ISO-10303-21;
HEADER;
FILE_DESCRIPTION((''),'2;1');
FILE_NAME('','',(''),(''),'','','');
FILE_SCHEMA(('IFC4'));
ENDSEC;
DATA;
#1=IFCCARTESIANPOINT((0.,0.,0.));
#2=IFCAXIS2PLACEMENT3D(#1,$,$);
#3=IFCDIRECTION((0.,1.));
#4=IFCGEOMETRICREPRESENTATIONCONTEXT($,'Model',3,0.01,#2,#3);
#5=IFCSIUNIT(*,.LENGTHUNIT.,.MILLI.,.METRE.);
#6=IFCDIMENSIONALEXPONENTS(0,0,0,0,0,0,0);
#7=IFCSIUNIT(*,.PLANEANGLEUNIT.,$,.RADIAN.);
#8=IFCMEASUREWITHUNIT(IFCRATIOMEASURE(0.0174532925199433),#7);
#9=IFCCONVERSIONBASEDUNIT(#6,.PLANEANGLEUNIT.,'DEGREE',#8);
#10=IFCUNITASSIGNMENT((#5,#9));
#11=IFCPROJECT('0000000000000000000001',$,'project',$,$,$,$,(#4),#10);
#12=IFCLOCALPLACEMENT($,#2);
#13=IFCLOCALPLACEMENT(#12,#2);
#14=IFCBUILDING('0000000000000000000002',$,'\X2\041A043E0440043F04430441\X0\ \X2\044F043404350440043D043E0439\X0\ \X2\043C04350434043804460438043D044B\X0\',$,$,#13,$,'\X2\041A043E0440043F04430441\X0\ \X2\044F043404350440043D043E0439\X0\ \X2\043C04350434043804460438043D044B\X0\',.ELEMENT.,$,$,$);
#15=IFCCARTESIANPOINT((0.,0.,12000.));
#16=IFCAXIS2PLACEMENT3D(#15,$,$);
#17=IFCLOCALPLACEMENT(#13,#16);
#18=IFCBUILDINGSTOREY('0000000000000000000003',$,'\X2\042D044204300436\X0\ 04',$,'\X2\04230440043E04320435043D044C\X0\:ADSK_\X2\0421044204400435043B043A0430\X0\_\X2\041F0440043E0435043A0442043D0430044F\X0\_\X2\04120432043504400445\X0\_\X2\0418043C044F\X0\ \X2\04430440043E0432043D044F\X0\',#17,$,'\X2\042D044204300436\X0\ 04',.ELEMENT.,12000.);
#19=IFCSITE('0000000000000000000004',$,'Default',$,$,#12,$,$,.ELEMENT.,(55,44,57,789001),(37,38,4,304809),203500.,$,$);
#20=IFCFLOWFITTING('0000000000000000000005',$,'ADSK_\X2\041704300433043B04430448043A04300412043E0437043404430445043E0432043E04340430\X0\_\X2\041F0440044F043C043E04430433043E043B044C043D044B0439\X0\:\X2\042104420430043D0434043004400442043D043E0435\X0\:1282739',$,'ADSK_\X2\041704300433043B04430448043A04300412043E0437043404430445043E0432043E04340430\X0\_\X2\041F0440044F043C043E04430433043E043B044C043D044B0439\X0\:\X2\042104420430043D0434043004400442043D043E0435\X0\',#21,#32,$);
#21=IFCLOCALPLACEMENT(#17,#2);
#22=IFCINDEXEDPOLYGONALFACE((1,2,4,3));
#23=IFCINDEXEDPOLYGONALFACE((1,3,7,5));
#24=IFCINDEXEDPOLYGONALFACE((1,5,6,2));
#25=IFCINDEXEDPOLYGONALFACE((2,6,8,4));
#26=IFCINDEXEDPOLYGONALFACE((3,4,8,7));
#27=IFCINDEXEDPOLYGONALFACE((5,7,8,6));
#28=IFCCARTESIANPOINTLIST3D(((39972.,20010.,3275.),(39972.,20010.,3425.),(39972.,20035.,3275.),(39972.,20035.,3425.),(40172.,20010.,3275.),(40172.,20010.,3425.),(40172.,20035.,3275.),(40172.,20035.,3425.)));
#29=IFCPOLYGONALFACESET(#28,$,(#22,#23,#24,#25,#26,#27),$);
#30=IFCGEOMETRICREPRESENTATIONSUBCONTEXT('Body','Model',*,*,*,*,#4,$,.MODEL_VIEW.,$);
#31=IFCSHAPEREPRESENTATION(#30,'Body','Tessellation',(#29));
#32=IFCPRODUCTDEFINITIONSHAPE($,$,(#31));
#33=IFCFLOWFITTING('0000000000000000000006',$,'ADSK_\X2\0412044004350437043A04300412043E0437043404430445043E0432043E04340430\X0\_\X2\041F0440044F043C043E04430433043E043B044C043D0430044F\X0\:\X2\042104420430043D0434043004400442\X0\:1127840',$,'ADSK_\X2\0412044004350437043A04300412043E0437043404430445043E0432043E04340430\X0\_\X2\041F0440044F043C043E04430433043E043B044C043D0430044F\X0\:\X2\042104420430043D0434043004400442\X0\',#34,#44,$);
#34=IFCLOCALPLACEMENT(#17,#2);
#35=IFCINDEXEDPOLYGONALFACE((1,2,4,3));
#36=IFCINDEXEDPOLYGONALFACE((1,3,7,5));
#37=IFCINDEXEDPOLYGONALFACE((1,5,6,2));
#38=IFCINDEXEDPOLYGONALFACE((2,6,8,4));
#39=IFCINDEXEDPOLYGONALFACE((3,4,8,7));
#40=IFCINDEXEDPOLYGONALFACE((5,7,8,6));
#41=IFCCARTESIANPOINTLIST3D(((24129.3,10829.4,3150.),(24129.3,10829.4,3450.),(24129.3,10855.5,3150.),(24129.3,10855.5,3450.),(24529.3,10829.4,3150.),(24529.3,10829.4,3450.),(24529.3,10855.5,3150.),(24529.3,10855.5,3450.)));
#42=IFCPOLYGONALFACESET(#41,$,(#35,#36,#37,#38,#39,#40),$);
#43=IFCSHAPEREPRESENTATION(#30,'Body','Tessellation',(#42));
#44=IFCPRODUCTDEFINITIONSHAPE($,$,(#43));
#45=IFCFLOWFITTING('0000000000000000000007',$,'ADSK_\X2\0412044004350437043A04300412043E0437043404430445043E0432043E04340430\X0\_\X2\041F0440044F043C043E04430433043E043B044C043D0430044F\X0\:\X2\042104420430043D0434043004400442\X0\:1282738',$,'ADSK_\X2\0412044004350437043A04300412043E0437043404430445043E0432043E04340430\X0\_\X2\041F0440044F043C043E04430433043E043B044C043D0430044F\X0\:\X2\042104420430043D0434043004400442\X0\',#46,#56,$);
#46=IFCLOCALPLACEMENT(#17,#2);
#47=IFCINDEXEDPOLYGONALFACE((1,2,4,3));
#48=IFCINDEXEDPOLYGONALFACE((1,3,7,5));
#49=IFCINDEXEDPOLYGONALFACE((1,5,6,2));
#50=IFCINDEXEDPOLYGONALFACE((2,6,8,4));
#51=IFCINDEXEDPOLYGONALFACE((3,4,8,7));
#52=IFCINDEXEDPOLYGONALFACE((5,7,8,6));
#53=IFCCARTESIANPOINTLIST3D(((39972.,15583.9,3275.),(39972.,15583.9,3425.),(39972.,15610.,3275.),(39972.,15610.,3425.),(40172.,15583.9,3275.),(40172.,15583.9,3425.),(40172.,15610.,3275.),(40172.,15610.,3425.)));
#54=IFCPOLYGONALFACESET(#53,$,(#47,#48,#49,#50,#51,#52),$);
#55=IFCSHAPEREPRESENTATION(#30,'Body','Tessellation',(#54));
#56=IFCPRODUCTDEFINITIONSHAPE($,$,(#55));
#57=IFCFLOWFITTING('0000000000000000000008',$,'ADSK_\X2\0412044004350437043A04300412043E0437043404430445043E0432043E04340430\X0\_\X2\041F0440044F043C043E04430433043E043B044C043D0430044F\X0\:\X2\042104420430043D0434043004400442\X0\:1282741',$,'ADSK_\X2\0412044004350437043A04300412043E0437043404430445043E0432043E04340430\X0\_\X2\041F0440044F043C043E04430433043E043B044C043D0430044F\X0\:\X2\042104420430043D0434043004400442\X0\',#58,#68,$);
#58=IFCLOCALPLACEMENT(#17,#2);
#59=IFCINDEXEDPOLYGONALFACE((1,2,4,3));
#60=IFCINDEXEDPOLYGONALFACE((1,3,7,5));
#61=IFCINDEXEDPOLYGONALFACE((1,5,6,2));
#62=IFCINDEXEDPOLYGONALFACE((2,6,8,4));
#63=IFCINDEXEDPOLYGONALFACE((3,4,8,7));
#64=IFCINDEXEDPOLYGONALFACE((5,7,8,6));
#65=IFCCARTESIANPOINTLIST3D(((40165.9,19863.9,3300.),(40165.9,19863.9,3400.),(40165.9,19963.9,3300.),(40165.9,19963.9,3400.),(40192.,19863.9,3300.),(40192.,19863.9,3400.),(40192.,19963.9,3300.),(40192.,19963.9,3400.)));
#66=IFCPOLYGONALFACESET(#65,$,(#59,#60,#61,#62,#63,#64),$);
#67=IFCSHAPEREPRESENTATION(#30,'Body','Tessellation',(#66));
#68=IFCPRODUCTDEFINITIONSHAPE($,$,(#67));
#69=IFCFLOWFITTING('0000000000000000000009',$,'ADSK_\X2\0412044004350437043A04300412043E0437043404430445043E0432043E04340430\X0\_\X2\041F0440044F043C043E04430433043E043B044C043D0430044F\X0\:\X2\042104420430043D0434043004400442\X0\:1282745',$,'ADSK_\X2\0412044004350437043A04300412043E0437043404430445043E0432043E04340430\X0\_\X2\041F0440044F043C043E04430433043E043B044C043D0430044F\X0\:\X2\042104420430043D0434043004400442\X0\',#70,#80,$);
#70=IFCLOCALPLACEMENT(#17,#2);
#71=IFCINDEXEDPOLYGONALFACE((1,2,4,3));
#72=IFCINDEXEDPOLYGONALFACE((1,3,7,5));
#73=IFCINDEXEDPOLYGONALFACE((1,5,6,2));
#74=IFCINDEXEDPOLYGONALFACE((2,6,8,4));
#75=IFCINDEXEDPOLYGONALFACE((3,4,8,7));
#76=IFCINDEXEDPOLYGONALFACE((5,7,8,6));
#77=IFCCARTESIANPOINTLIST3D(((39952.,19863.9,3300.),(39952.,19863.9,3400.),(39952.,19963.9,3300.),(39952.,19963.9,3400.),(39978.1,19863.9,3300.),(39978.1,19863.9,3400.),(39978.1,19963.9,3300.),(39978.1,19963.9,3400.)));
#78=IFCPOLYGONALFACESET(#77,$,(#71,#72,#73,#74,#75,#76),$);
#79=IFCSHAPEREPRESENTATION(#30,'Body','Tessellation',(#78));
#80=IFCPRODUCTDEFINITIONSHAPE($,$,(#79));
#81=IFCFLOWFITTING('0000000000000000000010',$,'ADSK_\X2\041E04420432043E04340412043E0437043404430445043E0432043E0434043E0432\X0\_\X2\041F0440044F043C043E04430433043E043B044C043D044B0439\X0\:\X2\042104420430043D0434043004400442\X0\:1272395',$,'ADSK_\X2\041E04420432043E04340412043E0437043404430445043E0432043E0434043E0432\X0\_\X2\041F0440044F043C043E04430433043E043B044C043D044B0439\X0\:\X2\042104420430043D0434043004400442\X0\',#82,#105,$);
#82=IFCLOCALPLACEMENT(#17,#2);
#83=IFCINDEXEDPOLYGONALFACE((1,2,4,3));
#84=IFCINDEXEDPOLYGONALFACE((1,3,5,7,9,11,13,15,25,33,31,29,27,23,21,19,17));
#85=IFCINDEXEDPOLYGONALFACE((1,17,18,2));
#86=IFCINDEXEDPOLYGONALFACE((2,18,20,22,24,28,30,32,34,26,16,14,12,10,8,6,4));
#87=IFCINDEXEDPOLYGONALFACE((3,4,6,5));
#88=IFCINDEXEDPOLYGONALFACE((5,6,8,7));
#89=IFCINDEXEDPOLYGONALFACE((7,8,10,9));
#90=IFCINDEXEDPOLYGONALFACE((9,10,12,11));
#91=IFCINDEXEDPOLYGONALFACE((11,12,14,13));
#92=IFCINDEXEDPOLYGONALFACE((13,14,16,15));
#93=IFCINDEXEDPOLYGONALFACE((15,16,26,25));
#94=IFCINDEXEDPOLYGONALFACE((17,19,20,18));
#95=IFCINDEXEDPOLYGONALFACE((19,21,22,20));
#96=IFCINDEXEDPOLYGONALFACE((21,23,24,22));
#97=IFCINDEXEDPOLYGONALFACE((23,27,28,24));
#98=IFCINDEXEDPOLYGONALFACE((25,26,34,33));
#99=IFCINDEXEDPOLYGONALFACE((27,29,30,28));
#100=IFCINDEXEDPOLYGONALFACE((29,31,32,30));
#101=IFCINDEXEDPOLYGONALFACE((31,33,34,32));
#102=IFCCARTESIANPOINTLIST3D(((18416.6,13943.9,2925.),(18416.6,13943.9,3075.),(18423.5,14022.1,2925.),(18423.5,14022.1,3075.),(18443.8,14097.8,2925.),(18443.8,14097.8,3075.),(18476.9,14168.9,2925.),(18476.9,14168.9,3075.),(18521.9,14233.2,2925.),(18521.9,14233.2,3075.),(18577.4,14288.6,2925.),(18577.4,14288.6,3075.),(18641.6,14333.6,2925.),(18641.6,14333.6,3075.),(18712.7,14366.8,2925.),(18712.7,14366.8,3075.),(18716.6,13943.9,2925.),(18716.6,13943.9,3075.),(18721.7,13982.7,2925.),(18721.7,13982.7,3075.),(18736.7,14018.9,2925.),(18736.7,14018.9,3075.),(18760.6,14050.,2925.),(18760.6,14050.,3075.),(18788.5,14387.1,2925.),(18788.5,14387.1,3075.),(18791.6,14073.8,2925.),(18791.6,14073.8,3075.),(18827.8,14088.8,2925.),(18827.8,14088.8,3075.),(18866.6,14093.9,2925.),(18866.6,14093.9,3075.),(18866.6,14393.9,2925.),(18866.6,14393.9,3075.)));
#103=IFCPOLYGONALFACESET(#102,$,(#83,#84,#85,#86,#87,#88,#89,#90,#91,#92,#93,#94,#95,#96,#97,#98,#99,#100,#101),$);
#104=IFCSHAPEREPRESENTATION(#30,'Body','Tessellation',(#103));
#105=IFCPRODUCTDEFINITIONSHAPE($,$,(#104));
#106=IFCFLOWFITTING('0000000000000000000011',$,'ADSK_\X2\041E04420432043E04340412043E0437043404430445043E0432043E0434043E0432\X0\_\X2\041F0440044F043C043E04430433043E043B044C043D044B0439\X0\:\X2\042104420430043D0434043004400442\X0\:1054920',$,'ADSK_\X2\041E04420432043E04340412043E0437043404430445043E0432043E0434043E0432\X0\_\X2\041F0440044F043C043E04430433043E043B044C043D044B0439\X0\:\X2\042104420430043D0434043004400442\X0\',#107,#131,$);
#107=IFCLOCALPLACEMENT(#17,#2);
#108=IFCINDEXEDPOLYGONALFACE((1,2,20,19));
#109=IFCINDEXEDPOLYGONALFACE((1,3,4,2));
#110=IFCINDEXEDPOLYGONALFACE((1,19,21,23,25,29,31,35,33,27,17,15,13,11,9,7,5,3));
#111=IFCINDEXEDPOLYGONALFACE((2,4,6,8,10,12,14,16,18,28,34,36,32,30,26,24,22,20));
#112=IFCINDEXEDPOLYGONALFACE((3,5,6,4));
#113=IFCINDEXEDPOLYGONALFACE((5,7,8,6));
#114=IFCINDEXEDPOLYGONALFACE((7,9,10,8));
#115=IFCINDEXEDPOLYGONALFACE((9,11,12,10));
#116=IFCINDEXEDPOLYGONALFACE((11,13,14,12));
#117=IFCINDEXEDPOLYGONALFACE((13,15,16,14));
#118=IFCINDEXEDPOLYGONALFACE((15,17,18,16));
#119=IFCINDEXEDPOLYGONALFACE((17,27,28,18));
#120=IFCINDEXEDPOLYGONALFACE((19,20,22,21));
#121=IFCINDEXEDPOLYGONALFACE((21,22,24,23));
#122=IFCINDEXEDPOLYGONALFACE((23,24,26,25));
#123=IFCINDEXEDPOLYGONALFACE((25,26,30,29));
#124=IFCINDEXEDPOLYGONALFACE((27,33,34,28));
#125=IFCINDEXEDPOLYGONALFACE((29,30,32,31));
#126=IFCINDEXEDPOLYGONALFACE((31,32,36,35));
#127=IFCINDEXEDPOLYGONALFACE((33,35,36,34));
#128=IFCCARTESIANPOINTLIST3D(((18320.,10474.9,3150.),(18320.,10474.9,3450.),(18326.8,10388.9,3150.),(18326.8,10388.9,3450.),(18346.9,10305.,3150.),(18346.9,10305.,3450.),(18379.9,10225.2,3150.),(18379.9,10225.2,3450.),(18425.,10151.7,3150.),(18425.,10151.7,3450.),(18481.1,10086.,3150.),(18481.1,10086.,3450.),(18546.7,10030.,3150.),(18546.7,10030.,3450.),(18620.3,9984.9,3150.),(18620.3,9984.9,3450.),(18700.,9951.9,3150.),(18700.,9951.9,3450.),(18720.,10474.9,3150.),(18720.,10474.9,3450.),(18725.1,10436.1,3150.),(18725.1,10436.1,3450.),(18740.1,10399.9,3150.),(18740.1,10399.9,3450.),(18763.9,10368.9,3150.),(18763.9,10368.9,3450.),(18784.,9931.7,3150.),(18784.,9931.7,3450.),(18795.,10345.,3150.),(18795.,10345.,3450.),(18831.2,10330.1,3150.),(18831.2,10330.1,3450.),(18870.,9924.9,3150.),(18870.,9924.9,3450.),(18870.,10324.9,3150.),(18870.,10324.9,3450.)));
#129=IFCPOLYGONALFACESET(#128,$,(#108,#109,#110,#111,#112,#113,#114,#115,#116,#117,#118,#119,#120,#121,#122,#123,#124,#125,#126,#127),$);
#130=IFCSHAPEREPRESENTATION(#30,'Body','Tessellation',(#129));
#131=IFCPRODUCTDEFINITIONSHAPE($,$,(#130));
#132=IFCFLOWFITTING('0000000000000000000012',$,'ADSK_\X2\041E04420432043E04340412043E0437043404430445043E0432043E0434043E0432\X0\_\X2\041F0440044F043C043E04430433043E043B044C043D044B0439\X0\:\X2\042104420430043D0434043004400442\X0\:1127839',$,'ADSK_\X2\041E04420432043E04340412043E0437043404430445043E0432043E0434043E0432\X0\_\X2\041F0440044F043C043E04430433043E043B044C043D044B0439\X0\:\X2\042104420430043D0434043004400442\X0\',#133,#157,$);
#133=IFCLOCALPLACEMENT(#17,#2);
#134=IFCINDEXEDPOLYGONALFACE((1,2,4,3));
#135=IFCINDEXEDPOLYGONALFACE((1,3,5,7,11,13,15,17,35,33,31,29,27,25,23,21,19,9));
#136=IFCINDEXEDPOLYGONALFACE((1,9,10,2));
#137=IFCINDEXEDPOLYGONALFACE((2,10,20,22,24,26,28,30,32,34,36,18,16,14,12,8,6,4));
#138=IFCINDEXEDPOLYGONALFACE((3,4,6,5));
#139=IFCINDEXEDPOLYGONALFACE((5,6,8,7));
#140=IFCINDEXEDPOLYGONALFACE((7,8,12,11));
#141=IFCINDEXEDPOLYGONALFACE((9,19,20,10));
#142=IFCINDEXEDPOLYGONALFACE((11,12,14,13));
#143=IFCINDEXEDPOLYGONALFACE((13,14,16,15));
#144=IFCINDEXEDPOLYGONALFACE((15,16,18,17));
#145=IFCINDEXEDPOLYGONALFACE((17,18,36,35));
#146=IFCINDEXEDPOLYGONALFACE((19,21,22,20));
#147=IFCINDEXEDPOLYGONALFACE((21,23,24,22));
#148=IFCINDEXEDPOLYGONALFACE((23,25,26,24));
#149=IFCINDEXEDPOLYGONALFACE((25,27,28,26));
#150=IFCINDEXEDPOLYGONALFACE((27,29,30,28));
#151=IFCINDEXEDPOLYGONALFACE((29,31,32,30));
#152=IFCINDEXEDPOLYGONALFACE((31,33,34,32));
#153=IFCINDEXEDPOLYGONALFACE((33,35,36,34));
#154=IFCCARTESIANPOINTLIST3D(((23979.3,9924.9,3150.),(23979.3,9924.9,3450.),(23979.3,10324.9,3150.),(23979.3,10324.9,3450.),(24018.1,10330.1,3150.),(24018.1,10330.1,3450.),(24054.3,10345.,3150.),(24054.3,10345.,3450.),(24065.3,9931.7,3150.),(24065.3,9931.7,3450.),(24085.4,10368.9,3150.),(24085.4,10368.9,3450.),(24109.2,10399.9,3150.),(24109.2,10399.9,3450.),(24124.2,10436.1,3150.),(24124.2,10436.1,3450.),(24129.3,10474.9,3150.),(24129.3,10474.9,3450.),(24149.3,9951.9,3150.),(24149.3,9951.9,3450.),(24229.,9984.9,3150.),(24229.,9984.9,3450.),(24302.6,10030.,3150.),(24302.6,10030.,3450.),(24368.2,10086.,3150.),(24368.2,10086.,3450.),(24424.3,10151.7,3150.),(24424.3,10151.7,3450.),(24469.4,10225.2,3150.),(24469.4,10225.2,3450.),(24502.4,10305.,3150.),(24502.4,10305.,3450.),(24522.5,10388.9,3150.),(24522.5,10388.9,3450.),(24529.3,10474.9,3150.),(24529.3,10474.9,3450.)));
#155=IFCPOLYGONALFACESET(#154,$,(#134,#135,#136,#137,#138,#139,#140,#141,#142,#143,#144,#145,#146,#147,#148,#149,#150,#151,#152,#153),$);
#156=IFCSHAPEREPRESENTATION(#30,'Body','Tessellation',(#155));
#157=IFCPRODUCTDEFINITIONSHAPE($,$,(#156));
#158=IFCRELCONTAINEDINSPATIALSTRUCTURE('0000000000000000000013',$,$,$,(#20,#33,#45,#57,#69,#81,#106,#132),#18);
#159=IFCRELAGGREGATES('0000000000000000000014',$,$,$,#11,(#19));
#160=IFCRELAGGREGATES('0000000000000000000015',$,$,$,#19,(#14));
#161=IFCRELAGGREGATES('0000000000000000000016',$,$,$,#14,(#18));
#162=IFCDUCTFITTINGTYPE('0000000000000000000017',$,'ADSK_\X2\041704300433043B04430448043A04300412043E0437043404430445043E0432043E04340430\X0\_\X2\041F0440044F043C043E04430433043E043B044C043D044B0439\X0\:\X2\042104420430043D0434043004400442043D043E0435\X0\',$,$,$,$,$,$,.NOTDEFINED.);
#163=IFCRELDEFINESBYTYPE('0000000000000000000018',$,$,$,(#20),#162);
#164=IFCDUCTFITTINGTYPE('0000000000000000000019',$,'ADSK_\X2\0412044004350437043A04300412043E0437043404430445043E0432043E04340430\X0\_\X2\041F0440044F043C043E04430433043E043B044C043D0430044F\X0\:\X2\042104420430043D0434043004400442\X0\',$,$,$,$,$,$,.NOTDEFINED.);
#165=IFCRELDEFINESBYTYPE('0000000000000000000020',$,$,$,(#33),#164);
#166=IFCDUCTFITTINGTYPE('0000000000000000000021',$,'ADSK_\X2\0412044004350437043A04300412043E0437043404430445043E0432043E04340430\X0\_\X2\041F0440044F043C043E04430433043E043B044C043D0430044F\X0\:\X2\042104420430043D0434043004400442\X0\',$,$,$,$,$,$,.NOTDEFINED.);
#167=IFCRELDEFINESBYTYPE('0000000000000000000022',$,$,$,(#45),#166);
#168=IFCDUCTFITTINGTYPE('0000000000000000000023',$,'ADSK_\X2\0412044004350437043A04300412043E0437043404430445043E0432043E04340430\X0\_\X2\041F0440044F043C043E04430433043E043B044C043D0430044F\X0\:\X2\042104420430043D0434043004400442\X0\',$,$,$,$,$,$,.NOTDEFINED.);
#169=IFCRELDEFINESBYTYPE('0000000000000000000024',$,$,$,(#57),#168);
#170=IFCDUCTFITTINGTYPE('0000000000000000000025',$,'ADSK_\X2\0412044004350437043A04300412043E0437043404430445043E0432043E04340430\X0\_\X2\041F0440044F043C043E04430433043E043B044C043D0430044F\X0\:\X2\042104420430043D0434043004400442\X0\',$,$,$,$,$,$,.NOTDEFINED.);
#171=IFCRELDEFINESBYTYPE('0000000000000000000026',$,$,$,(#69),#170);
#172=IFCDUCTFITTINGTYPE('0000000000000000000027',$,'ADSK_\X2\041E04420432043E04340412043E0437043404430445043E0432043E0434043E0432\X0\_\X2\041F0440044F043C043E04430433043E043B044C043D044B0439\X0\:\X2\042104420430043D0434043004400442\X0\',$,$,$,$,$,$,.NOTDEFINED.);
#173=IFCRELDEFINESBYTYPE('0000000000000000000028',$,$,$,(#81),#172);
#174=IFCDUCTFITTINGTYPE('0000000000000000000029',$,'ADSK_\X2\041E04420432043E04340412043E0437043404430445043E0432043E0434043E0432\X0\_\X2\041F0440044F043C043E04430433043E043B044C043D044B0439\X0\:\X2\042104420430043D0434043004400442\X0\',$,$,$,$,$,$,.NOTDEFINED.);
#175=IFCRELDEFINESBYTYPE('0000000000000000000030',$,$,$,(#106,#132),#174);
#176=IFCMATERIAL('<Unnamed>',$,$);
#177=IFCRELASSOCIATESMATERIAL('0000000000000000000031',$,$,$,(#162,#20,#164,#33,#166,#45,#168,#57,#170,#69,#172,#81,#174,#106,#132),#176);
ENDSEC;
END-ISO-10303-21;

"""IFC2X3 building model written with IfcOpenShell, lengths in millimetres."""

from ifc_helpers import new_model, entity, si_unit, converted_unit, direction, frame, frame_2d, origin, origin_2d_with_axis, place, context, subcontext, project, spatial, polyline, circle_curve, parameter, trimmed, segment, composite_curve, rectangle, outline, extrude, source, transform, mapped, material, type_object, type_shapes, element, save


model = new_model("IFC2X3")

# Units and contexts
model_context = context("Model", 3, precision=0.01, world=origin(), true_north=direction((0.0, 1.0)))
body_context = subcontext(model_context, "Body", "Model", "MODEL_VIEW")
ifc_project = project(units=[si_unit("LENGTHUNIT", "METRE", prefix="MILLI"), converted_unit("PLANEANGLEUNIT", "DEGREE", entity("IfcRatioMeasure", 0.0174532925199433), si_unit("PLANEANGLEUNIT", "RADIAN"), dimensions=[0, 0, 0, 0, 0, 0, 0])], contexts=[model_context])

# Site, building, storey
site_placement = place(None, origin())
site = spatial("IfcSite", under=ifc_project, at=site_placement, Name="Default", CompositionType="ELEMENT", RefLatitude=(55, 44, 57, 789001), RefLongitude=(37, 38, 4, 304809), RefElevation=203500.0)
building_placement = place(site_placement, origin())
building = spatial("IfcBuilding", under=site, at=building_placement, Name="Корпус ядерной медицины", LongName="Корпус ядерной медицины", CompositionType="ELEMENT")
storey_placement = place(building_placement, frame((0.0, 0.0, 12000.0)))
storey = spatial("IfcBuildingStorey", under=building, at=storey_placement, Name="Этаж 04", ObjectType="Уровень:ADSK_Стрелка_Проектная_Вверх_Имя уровня", LongName="Этаж 04", CompositionType="ELEMENT", Elevation=12000.0)

# Flow fittings
ifc_material = material(Name="<Unnamed>")
duct_fitting_type_1 = type_object("IfcDuctFittingType", Name="ADSK_ЗаглушкаВоздуховода_Прямоугольный:Стандартное", PredefinedType="NOTDEFINED", material=ifc_material)
shared_shape_1 = source(origin(), body_context, "Body", "SweptSolid", [
    extrude(rectangle(XDim=25.0, YDim=200.0, at=origin_2d_with_axis()), frame((12.5, 0.0, -75.0)), (0.0, 0.0, 1.0), 150.0),
])
type_shapes(duct_fitting_type_1, [shared_shape_1])
flow_fitting_1_placement = place(storey_placement, frame((40072.0, 20010.0, 3350.0), z_axis=(0.0, 0.0, 1.0), x_axis=(0.0, 1.0, 0.0)))
element("IfcFlowFitting", 1, at=flow_fitting_1_placement, inside=storey, type_object=duct_fitting_type_1, material=ifc_material, Name="ADSK_ЗаглушкаВоздуховода_Прямоугольный:Стандартное:1282739", ObjectType="ADSK_ЗаглушкаВоздуховода_Прямоугольный:Стандартное", context=body_context, shape_type="MappedRepresentation", body=[
    mapped(shared_shape_1, transform((0.0, 0.0, 0.0), scale=1.0)),
])
duct_fitting_type_2 = type_object("IfcDuctFittingType", Name="ADSK_ВрезкаВоздуховода_Прямоугольная:Стандарт", PredefinedType="NOTDEFINED", material=ifc_material)
shared_shape_2 = source(origin(), body_context, "Body", "SweptSolid", [
    extrude(rectangle(XDim=26.1, YDim=300.0, at=origin_2d_with_axis()), frame((7.0, 0.0, -200.0)), (0.0, 0.0, 1.0), 400.0),
])
type_shapes(duct_fitting_type_2, [shared_shape_2])
flow_fitting_2_placement = place(storey_placement, frame((24329.3, 10849.4, 3300.0), z_axis=(-1.0, 0.0, 0.0), x_axis=(0.0, -1.0, 0.0)))
element("IfcFlowFitting", 2, at=flow_fitting_2_placement, inside=storey, type_object=duct_fitting_type_2, material=ifc_material, Name="ADSK_ВрезкаВоздуховода_Прямоугольная:Стандарт:1127840", ObjectType="ADSK_ВрезкаВоздуховода_Прямоугольная:Стандарт", context=body_context, shape_type="MappedRepresentation", body=[
    mapped(shared_shape_2, transform((0.0, 0.0, 0.0), scale=1.0)),
])
duct_fitting_type_3 = type_object("IfcDuctFittingType", Name="ADSK_ВрезкаВоздуховода_Прямоугольная:Стандарт", PredefinedType="NOTDEFINED", material=ifc_material)
shared_shape_3 = source(origin(), body_context, "Body", "SweptSolid", [
    extrude(rectangle(XDim=200.0, YDim=26.1, at=origin_2d_with_axis()), frame((7.0, 0.0, -75.0), z_axis=(0.0, 0.0, 1.0), x_axis=(0.0, -1.0, 0.0)), (0.0, 0.0, 1.0), 150.0),
])
type_shapes(duct_fitting_type_3, [shared_shape_3])
flow_fitting_3_placement = place(storey_placement, frame((40072.0, 15590.0, 3350.0), z_axis=(0.0, 0.0, -1.0), x_axis=(0.0, 1.0, 0.0)))
element("IfcFlowFitting", 3, at=flow_fitting_3_placement, inside=storey, type_object=duct_fitting_type_3, material=ifc_material, Name="ADSK_ВрезкаВоздуховода_Прямоугольная:Стандарт:1282738", ObjectType="ADSK_ВрезкаВоздуховода_Прямоугольная:Стандарт", context=body_context, shape_type="MappedRepresentation", body=[
    mapped(shared_shape_3, transform((0.0, 0.0, 0.0), scale=1.0)),
])
duct_fitting_type_4 = type_object("IfcDuctFittingType", Name="ADSK_ВрезкаВоздуховода_Прямоугольная:Стандарт", PredefinedType="NOTDEFINED", material=ifc_material)
shared_shape_4 = source(origin(), body_context, "Body", "SweptSolid", [
    extrude(rectangle(XDim=26.1, YDim=100.0, at=origin_2d_with_axis()), frame((7.0, 0.0, -50.0)), (0.0, 0.0, 1.0), 100.0),
])
type_shapes(duct_fitting_type_4, [shared_shape_4])
flow_fitting_4_placement = place(storey_placement, frame((40172.0, 19913.9, 3350.0), z_axis=(0.0, 0.0, -1.0), x_axis=(1.0, 0.0, 0.0)))
element("IfcFlowFitting", 4, at=flow_fitting_4_placement, inside=storey, type_object=duct_fitting_type_4, material=ifc_material, Name="ADSK_ВрезкаВоздуховода_Прямоугольная:Стандарт:1282741", ObjectType="ADSK_ВрезкаВоздуховода_Прямоугольная:Стандарт", context=body_context, shape_type="MappedRepresentation", body=[
    mapped(shared_shape_4, transform((0.0, 0.0, 0.0), scale=1.0)),
])
duct_fitting_type_5 = type_object("IfcDuctFittingType", Name="ADSK_ВрезкаВоздуховода_Прямоугольная:Стандарт", PredefinedType="NOTDEFINED", material=ifc_material)
shared_shape_5 = source(origin(), body_context, "Body", "SweptSolid", [
    extrude(rectangle(XDim=100.0, YDim=26.1, at=origin_2d_with_axis()), frame((7.0, 0.0, -50.0), z_axis=(0.0, 0.0, 1.0), x_axis=(0.0, -1.0, 0.0)), (0.0, 0.0, 1.0), 100.0),
])
type_shapes(duct_fitting_type_5, [shared_shape_5])
flow_fitting_5_placement = place(storey_placement, frame((39972.0, 19913.9, 3350.0), z_axis=(0.0, 0.0, -1.0), x_axis=(-1.0, 0.0, 0.0)))
element("IfcFlowFitting", 5, at=flow_fitting_5_placement, inside=storey, type_object=duct_fitting_type_5, material=ifc_material, Name="ADSK_ВрезкаВоздуховода_Прямоугольная:Стандарт:1282745", ObjectType="ADSK_ВрезкаВоздуховода_Прямоугольная:Стандарт", context=body_context, shape_type="MappedRepresentation", body=[
    mapped(shared_shape_5, transform((0.0, 0.0, 0.0), scale=1.0)),
])
duct_fitting_type_6 = type_object("IfcDuctFittingType", Name="ADSK_ОтводВоздуховодов_Прямоугольный:Стандарт", PredefinedType="NOTDEFINED", material=ifc_material)
shared_shape_6 = source(origin(), body_context, "Body", "SweptSolid", [
    extrude(outline(composite_curve([segment(polyline([(-300.0, -150.0), (0.0, -150.0)]), True, "CONTINUOUS"), segment(trimmed(circle_curve(frame_2d((150.0, -150.0), x_axis=(0.0, 1.0)), 150.0), [parameter(0.0)], [parameter(90.0)], True, "PARAMETER"), False, "CONTINUOUS"), segment(polyline([(150.0, 0.0), (150.0, 300.0)]), True, "CONTINUOUS"), segment(trimmed(circle_curve(frame_2d((150.0, -150.0), x_axis=(0.0, 1.0)), 450.0), [parameter(0.0)], [parameter(90.0)], True, "PARAMETER"), True, "CONTINUOUS")], self_intersect=False)), frame((-150.0, 150.0, -75.0), z_axis=(0.0, 0.0, 1.0), x_axis=(-1.0, 0.0, 0.0)), (0.0, 0.0, 1.0), 150.0),
])
type_shapes(duct_fitting_type_6, [shared_shape_6])
flow_fitting_6_placement = place(storey_placement, frame((18566.6, 14243.9, 3000.0), z_axis=(0.0, 0.0, 1.0), x_axis=(-1.0, 0.0, 0.0)))
element("IfcFlowFitting", 6, at=flow_fitting_6_placement, inside=storey, type_object=duct_fitting_type_6, material=ifc_material, Name="ADSK_ОтводВоздуховодов_Прямоугольный:Стандарт:1272395", ObjectType="ADSK_ОтводВоздуховодов_Прямоугольный:Стандарт", context=body_context, shape_type="MappedRepresentation", body=[
    mapped(shared_shape_6, transform((0.0, 0.0, 0.0), scale=1.0)),
])
duct_fitting_type_7 = type_object("IfcDuctFittingType", Name="ADSK_ОтводВоздуховодов_Прямоугольный:Стандарт", PredefinedType="NOTDEFINED", material=ifc_material)
shared_shape_7 = source(origin(), body_context, "Body", "SweptSolid", [
    extrude(outline(composite_curve([segment(polyline([(-375.0, -175.0), (25.0, -175.0)]), True, "CONTINUOUS"), segment(trimmed(circle_curve(frame_2d((175.0, -175.0), x_axis=(0.0, 1.0)), 150.0), [parameter(0.0)], [parameter(90.0)], True, "PARAMETER"), False, "CONTINUOUS"), segment(polyline([(175.0, -25.0), (175.0, 375.0)]), True, "CONTINUOUS"), segment(trimmed(circle_curve(frame_2d((175.0, -175.0), x_axis=(0.0, 1.0)), 550.0), [parameter(0.0)], [parameter(90.0)], True, "PARAMETER"), True, "CONTINUOUS")], self_intersect=False)), frame((-175.0, 175.0, -150.0), z_axis=(0.0, 0.0, 1.0), x_axis=(-1.0, 0.0, 0.0)), (0.0, 0.0, 1.0), 300.0),
])
type_shapes(duct_fitting_type_7, [shared_shape_7])
flow_fitting_7_placement = place(storey_placement, frame((18520.0, 10124.9, 3300.0), z_axis=(0.0, 0.0, 1.0), x_axis=(0.0, -1.0, 0.0)))
element("IfcFlowFitting", 7, at=flow_fitting_7_placement, inside=storey, type_object=duct_fitting_type_7, material=ifc_material, Name="ADSK_ОтводВоздуховодов_Прямоугольный:Стандарт:1054920", ObjectType="ADSK_ОтводВоздуховодов_Прямоугольный:Стандарт", context=body_context, shape_type="MappedRepresentation", body=[
    mapped(shared_shape_7, transform((0.0, 0.0, 0.0), scale=1.0)),
])
flow_fitting_8_placement = place(storey_placement, frame((24329.3, 10124.9, 3300.0)))
element("IfcFlowFitting", 8, at=flow_fitting_8_placement, inside=storey, type_object=duct_fitting_type_7, material=ifc_material, Name="ADSK_ОтводВоздуховодов_Прямоугольный:Стандарт:1127839", ObjectType="ADSK_ОтводВоздуховодов_Прямоугольный:Стандарт", context=body_context, shape_type="MappedRepresentation", body=[
    mapped(shared_shape_7, transform((0.0, 0.0, 0.0), scale=1.0)),
])

save(model, "model.ifc")
